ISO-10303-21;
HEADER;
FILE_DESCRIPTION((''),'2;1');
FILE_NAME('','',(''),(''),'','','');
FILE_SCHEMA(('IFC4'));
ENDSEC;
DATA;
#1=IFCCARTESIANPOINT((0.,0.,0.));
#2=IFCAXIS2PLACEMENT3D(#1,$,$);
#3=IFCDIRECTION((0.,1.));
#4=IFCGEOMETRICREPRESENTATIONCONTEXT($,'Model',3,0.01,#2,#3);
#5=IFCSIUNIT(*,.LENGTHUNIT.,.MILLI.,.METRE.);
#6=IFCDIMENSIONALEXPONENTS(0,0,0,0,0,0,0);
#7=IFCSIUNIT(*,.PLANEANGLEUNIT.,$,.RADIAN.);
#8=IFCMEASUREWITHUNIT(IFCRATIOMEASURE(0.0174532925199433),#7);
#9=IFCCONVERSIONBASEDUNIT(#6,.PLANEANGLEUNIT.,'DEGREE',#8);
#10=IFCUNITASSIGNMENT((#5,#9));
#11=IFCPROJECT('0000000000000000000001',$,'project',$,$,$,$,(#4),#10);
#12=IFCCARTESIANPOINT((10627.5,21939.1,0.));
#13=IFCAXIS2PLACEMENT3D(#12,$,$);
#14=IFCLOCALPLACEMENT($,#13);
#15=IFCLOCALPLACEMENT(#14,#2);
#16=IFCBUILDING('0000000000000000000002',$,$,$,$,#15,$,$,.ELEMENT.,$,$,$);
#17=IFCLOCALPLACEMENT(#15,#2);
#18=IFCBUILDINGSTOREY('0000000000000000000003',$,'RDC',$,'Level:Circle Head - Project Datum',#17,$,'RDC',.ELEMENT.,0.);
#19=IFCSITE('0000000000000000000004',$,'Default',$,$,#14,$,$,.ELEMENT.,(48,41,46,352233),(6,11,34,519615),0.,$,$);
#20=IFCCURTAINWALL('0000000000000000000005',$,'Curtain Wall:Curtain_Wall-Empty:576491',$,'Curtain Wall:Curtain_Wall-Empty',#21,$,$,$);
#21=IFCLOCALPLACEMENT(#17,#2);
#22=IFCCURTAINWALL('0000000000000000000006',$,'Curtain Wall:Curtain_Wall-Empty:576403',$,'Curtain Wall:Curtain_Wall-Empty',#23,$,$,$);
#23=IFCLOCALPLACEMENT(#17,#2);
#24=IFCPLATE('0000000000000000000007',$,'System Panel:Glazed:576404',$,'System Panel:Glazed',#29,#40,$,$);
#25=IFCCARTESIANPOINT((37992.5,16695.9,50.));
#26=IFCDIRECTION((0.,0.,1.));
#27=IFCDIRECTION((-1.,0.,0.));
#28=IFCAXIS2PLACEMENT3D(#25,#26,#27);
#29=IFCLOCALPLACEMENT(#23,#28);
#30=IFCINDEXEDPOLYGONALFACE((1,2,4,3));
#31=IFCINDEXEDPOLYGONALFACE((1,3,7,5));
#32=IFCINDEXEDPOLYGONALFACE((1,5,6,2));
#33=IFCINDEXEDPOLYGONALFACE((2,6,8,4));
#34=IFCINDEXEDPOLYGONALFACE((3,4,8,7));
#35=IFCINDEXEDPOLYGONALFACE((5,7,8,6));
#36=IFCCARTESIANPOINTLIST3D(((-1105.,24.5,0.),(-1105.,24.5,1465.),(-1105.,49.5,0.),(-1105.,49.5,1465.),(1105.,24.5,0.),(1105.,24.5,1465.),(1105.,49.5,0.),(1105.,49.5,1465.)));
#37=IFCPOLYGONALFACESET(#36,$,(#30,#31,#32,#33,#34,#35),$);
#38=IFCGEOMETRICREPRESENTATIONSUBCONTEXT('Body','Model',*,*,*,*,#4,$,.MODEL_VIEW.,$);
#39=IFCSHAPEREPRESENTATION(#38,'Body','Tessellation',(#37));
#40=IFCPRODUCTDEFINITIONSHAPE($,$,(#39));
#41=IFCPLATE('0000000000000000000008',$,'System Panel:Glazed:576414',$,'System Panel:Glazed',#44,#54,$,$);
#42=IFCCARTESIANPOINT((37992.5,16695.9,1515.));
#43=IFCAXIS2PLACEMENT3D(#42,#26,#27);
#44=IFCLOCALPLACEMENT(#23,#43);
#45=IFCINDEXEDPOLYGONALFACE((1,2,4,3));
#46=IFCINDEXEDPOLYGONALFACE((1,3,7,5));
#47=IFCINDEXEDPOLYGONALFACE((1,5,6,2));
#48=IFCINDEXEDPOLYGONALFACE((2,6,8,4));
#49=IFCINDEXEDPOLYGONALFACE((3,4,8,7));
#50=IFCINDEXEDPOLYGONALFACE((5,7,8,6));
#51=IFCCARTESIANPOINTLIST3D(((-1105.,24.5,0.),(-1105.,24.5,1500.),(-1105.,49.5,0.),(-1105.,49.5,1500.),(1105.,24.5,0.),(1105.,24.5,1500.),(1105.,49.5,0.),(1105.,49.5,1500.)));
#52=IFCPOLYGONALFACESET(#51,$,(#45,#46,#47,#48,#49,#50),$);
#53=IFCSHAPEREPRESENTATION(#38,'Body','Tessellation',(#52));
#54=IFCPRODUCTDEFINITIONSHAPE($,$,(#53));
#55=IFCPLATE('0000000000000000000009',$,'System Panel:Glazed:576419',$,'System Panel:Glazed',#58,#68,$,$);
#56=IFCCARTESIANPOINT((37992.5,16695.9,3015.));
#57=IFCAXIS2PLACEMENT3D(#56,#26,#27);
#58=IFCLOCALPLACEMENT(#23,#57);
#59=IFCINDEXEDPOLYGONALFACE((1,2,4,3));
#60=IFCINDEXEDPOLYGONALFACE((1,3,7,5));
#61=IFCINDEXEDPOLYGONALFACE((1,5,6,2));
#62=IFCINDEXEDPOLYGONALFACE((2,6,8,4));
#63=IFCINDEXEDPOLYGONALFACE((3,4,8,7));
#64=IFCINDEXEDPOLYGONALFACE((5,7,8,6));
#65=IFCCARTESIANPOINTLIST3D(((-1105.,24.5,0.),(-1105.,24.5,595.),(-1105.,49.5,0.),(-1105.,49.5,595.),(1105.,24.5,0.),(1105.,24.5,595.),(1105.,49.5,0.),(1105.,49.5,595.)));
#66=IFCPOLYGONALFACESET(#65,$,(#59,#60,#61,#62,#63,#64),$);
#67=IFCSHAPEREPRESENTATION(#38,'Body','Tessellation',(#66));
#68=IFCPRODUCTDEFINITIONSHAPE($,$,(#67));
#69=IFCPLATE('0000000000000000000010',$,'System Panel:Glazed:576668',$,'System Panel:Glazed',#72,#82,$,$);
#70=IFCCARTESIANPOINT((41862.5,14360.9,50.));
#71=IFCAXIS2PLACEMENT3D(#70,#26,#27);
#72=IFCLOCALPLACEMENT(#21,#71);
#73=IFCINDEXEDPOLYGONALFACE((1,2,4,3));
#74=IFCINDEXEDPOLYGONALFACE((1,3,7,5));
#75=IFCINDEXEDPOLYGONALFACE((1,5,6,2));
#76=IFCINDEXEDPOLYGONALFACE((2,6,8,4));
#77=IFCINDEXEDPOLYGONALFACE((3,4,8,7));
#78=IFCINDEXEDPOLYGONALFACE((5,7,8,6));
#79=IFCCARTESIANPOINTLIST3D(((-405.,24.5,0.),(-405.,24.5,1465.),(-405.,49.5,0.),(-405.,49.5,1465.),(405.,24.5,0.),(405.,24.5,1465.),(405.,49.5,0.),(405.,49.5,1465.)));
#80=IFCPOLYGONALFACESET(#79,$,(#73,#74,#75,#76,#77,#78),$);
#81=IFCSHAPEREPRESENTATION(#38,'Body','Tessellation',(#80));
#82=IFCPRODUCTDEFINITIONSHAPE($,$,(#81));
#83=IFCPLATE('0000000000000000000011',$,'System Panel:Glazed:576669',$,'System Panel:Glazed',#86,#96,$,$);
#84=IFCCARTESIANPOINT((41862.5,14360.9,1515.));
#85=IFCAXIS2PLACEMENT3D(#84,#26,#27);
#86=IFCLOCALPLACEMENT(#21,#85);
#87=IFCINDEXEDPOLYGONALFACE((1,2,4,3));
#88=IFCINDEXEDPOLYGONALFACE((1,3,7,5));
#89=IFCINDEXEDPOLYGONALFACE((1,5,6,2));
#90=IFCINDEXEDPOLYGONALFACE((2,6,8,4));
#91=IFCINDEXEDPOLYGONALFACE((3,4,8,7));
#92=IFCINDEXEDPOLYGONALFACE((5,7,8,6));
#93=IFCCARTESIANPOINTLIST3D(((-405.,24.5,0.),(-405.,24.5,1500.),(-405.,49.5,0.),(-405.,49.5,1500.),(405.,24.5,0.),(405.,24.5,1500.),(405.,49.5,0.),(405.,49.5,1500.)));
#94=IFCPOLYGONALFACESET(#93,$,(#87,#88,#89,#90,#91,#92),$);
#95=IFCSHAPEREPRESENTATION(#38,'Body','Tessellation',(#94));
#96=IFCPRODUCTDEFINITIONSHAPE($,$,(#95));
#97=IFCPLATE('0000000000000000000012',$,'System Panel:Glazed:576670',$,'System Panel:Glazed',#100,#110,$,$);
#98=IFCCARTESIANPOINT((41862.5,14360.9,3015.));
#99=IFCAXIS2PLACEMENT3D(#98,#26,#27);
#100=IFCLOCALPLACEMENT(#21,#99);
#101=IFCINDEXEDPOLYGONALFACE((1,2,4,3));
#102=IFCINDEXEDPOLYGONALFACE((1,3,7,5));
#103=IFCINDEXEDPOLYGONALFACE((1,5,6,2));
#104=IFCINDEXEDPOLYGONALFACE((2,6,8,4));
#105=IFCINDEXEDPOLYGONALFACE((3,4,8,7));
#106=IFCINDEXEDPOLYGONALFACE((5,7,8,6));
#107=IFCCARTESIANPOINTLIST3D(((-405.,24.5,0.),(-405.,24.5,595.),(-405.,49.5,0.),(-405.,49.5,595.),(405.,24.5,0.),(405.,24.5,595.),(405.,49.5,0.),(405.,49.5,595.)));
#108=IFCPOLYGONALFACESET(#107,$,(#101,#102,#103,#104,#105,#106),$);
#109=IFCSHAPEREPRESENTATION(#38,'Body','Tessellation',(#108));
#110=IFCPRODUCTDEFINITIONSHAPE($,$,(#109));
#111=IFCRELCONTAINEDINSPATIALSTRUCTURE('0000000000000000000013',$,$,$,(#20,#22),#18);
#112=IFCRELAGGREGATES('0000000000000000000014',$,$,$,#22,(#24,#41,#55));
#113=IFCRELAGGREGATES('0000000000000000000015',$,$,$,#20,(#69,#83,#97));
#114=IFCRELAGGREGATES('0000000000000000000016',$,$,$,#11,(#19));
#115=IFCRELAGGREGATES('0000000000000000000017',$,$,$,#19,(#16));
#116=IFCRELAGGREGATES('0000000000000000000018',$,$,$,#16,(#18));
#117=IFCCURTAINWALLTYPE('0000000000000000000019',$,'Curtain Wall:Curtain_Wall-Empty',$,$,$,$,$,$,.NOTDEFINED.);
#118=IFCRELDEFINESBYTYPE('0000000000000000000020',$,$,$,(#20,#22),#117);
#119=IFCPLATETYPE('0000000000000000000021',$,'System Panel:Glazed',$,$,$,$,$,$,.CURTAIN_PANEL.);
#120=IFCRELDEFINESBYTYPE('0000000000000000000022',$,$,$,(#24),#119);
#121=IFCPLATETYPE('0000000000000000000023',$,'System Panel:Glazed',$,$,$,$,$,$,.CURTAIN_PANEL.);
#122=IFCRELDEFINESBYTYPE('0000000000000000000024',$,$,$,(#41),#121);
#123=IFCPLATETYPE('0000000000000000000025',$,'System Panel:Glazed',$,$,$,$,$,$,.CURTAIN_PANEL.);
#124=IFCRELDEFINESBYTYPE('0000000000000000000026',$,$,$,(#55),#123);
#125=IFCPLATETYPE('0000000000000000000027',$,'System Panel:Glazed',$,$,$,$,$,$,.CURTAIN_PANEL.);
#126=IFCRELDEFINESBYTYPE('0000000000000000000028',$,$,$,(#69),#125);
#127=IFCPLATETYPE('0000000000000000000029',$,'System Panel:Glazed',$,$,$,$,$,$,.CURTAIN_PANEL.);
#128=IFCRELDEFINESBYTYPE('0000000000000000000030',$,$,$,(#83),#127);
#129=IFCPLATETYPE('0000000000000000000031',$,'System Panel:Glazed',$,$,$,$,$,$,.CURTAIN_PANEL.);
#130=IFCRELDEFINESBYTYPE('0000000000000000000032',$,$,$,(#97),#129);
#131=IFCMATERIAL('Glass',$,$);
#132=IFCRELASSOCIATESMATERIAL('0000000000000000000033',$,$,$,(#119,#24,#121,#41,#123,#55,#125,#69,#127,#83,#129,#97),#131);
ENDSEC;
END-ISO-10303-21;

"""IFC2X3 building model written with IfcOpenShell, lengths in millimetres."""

from ifc_helpers import new_model, entity, si_unit, converted_unit, direction, frame, origin, origin_2d_with_axis, place, context, subcontext, project, spatial, rectangle, extrude, source, transform, mapped, material, type_object, type_shapes, element, aggregate, save


model = new_model("IFC2X3")

# Units and contexts
model_context = context("Model", 3, precision=0.01, world=origin(), true_north=direction((0.0, 1.0)))
body_context = subcontext(model_context, "Body", "Model", "MODEL_VIEW")
ifc_project = project(units=[si_unit("LENGTHUNIT", "METRE", prefix="MILLI"), converted_unit("PLANEANGLEUNIT", "DEGREE", entity("IfcRatioMeasure", 0.0174532925199433), si_unit("PLANEANGLEUNIT", "RADIAN"), dimensions=[0, 0, 0, 0, 0, 0, 0])], contexts=[model_context])

# Site, building, storey
site_placement = place(None, frame((10627.5, 21939.1, 0.0)))
site = spatial("IfcSite", under=ifc_project, at=site_placement, Name="Default", CompositionType="ELEMENT", RefLatitude=(48, 41, 46, 352233), RefLongitude=(6, 11, 34, 519615), RefElevation=0.0)
building_placement = place(site_placement, origin())
building = spatial("IfcBuilding", under=site, at=building_placement, CompositionType="ELEMENT")
storey_placement = place(building_placement, origin())
storey = spatial("IfcBuildingStorey", under=building, at=storey_placement, Name="RDC", ObjectType="Level:Circle Head - Project Datum", LongName="RDC", CompositionType="ELEMENT", Elevation=0.0)

# Curtain walls
curtain_wall_type = type_object("IfcCurtainWallType", Name="Curtain Wall:Curtain_Wall-Empty", PredefinedType="NOTDEFINED")
curtain_wall_1_placement = place(storey_placement, origin())
curtain_wall_1 = element("IfcCurtainWall", 1, at=curtain_wall_1_placement, inside=storey, type_object=curtain_wall_type, Name="Curtain Wall:Curtain_Wall-Empty:576491", ObjectType="Curtain Wall:Curtain_Wall-Empty")
curtain_wall_2_placement = place(storey_placement, origin())
curtain_wall_2 = element("IfcCurtainWall", 2, at=curtain_wall_2_placement, inside=storey, type_object=curtain_wall_type, Name="Curtain Wall:Curtain_Wall-Empty:576403", ObjectType="Curtain Wall:Curtain_Wall-Empty")

# Plates
ifc_material_1 = material(Name="Glass")
plate_type_1 = type_object("IfcPlateType", Name="System Panel:Glazed", PredefinedType="CURTAIN_PANEL", material=ifc_material_1)
shared_shape_1 = source(origin(), body_context, "Body", "SweptSolid", [
    extrude(rectangle(XDim=25.0, YDim=2210.0, at=origin_2d_with_axis()), frame((0.0, 37.0, 0.0), z_axis=(0.0, 0.0, 1.0), x_axis=(0.0, 1.0, 0.0)), (0.0, 0.0, 1.0), 1465.0),
])
type_shapes(plate_type_1, [shared_shape_1])
plate_1_placement = place(curtain_wall_2_placement, frame((37992.5, 16695.9, 50.0), z_axis=(0.0, 0.0, 1.0), x_axis=(-1.0, 0.0, 0.0)))
plate_1 = element("IfcPlate", 3, at=plate_1_placement, type_object=plate_type_1, material=ifc_material_1, Name="System Panel:Glazed:576404", ObjectType="System Panel:Glazed", context=body_context, shape_type="MappedRepresentation", body=[
    mapped(shared_shape_1, transform((0.0, 0.0, 0.0), scale=1.0)),
])
plate_type_2 = type_object("IfcPlateType", Name="System Panel:Glazed", PredefinedType="CURTAIN_PANEL", material=ifc_material_1)
shared_shape_2 = source(origin(), body_context, "Body", "SweptSolid", [
    extrude(rectangle(XDim=25.0, YDim=2210.0, at=origin_2d_with_axis()), frame((0.0, 37.0, 0.0), z_axis=(0.0, 0.0, 1.0), x_axis=(0.0, 1.0, 0.0)), (0.0, 0.0, 1.0), 1500.0),
])
type_shapes(plate_type_2, [shared_shape_2])
plate_2_placement = place(curtain_wall_2_placement, frame((37992.5, 16695.9, 1515.0), z_axis=(0.0, 0.0, 1.0), x_axis=(-1.0, 0.0, 0.0)))
plate_2 = element("IfcPlate", 4, at=plate_2_placement, type_object=plate_type_2, material=ifc_material_1, Name="System Panel:Glazed:576414", ObjectType="System Panel:Glazed", context=body_context, shape_type="MappedRepresentation", body=[
    mapped(shared_shape_2, transform((0.0, 0.0, 0.0), scale=1.0)),
])
plate_type_3 = type_object("IfcPlateType", Name="System Panel:Glazed", PredefinedType="CURTAIN_PANEL", material=ifc_material_1)
shared_shape_3 = source(origin(), body_context, "Body", "SweptSolid", [
    extrude(rectangle(XDim=25.0, YDim=2210.0, at=origin_2d_with_axis()), frame((0.0, 37.0, 0.0), z_axis=(0.0, 0.0, 1.0), x_axis=(0.0, 1.0, 0.0)), (0.0, 0.0, 1.0), 595.0),
])
type_shapes(plate_type_3, [shared_shape_3])
plate_3_placement = place(curtain_wall_2_placement, frame((37992.5, 16695.9, 3015.0), z_axis=(0.0, 0.0, 1.0), x_axis=(-1.0, 0.0, 0.0)))
plate_3 = element("IfcPlate", 5, at=plate_3_placement, type_object=plate_type_3, material=ifc_material_1, Name="System Panel:Glazed:576419", ObjectType="System Panel:Glazed", context=body_context, shape_type="MappedRepresentation", body=[
    mapped(shared_shape_3, transform((0.0, 0.0, 0.0), scale=1.0)),
])
aggregate(curtain_wall_2, [plate_1, plate_2, plate_3])
plate_type_4 = type_object("IfcPlateType", Name="System Panel:Glazed", PredefinedType="CURTAIN_PANEL", material=ifc_material_1)
shared_shape_4 = source(origin(), body_context, "Body", "SweptSolid", [
    extrude(rectangle(XDim=25.0, YDim=810.0, at=origin_2d_with_axis()), frame((0.0, 37.0, 0.0), z_axis=(0.0, 0.0, 1.0), x_axis=(0.0, 1.0, 0.0)), (0.0, 0.0, 1.0), 1465.0),
])
type_shapes(plate_type_4, [shared_shape_4])
plate_4_placement = place(curtain_wall_1_placement, frame((41862.5, 14360.9, 50.0), z_axis=(0.0, 0.0, 1.0), x_axis=(-1.0, 0.0, 0.0)))
plate_4 = element("IfcPlate", 6, at=plate_4_placement, type_object=plate_type_4, material=ifc_material_1, Name="System Panel:Glazed:576668", ObjectType="System Panel:Glazed", context=body_context, shape_type="MappedRepresentation", body=[
    mapped(shared_shape_4, transform((0.0, 0.0, 0.0), scale=1.0)),
])
plate_type_5 = type_object("IfcPlateType", Name="System Panel:Glazed", PredefinedType="CURTAIN_PANEL", material=ifc_material_1)
shared_shape_5 = source(origin(), body_context, "Body", "SweptSolid", [
    extrude(rectangle(XDim=25.0, YDim=810.0, at=origin_2d_with_axis()), frame((0.0, 37.0, 0.0), z_axis=(0.0, 0.0, 1.0), x_axis=(0.0, 1.0, 0.0)), (0.0, 0.0, 1.0), 1500.0),
])
type_shapes(plate_type_5, [shared_shape_5])
plate_5_placement = place(curtain_wall_1_placement, frame((41862.5, 14360.9, 1515.0), z_axis=(0.0, 0.0, 1.0), x_axis=(-1.0, 0.0, 0.0)))
plate_5 = element("IfcPlate", 7, at=plate_5_placement, type_object=plate_type_5, material=ifc_material_1, Name="System Panel:Glazed:576669", ObjectType="System Panel:Glazed", context=body_context, shape_type="MappedRepresentation", body=[
    mapped(shared_shape_5, transform((0.0, 0.0, 0.0), scale=1.0)),
])
plate_type_6 = type_object("IfcPlateType", Name="System Panel:Glazed", PredefinedType="CURTAIN_PANEL", material=ifc_material_1)
shared_shape_6 = source(origin(), body_context, "Body", "SweptSolid", [
    extrude(rectangle(XDim=25.0, YDim=810.0, at=origin_2d_with_axis()), frame((0.0, 37.0, 0.0), z_axis=(0.0, 0.0, 1.0), x_axis=(0.0, 1.0, 0.0)), (0.0, 0.0, 1.0), 595.0),
])
type_shapes(plate_type_6, [shared_shape_6])
plate_6_placement = place(curtain_wall_1_placement, frame((41862.5, 14360.9, 3015.0), z_axis=(0.0, 0.0, 1.0), x_axis=(-1.0, 0.0, 0.0)))
plate_6 = element("IfcPlate", 8, at=plate_6_placement, type_object=plate_type_6, material=ifc_material_1, Name="System Panel:Glazed:576670", ObjectType="System Panel:Glazed", context=body_context, shape_type="MappedRepresentation", body=[
    mapped(shared_shape_6, transform((0.0, 0.0, 0.0), scale=1.0)),
])
aggregate(curtain_wall_1, [plate_4, plate_5, plate_6])

save(model, "model.ifc")
